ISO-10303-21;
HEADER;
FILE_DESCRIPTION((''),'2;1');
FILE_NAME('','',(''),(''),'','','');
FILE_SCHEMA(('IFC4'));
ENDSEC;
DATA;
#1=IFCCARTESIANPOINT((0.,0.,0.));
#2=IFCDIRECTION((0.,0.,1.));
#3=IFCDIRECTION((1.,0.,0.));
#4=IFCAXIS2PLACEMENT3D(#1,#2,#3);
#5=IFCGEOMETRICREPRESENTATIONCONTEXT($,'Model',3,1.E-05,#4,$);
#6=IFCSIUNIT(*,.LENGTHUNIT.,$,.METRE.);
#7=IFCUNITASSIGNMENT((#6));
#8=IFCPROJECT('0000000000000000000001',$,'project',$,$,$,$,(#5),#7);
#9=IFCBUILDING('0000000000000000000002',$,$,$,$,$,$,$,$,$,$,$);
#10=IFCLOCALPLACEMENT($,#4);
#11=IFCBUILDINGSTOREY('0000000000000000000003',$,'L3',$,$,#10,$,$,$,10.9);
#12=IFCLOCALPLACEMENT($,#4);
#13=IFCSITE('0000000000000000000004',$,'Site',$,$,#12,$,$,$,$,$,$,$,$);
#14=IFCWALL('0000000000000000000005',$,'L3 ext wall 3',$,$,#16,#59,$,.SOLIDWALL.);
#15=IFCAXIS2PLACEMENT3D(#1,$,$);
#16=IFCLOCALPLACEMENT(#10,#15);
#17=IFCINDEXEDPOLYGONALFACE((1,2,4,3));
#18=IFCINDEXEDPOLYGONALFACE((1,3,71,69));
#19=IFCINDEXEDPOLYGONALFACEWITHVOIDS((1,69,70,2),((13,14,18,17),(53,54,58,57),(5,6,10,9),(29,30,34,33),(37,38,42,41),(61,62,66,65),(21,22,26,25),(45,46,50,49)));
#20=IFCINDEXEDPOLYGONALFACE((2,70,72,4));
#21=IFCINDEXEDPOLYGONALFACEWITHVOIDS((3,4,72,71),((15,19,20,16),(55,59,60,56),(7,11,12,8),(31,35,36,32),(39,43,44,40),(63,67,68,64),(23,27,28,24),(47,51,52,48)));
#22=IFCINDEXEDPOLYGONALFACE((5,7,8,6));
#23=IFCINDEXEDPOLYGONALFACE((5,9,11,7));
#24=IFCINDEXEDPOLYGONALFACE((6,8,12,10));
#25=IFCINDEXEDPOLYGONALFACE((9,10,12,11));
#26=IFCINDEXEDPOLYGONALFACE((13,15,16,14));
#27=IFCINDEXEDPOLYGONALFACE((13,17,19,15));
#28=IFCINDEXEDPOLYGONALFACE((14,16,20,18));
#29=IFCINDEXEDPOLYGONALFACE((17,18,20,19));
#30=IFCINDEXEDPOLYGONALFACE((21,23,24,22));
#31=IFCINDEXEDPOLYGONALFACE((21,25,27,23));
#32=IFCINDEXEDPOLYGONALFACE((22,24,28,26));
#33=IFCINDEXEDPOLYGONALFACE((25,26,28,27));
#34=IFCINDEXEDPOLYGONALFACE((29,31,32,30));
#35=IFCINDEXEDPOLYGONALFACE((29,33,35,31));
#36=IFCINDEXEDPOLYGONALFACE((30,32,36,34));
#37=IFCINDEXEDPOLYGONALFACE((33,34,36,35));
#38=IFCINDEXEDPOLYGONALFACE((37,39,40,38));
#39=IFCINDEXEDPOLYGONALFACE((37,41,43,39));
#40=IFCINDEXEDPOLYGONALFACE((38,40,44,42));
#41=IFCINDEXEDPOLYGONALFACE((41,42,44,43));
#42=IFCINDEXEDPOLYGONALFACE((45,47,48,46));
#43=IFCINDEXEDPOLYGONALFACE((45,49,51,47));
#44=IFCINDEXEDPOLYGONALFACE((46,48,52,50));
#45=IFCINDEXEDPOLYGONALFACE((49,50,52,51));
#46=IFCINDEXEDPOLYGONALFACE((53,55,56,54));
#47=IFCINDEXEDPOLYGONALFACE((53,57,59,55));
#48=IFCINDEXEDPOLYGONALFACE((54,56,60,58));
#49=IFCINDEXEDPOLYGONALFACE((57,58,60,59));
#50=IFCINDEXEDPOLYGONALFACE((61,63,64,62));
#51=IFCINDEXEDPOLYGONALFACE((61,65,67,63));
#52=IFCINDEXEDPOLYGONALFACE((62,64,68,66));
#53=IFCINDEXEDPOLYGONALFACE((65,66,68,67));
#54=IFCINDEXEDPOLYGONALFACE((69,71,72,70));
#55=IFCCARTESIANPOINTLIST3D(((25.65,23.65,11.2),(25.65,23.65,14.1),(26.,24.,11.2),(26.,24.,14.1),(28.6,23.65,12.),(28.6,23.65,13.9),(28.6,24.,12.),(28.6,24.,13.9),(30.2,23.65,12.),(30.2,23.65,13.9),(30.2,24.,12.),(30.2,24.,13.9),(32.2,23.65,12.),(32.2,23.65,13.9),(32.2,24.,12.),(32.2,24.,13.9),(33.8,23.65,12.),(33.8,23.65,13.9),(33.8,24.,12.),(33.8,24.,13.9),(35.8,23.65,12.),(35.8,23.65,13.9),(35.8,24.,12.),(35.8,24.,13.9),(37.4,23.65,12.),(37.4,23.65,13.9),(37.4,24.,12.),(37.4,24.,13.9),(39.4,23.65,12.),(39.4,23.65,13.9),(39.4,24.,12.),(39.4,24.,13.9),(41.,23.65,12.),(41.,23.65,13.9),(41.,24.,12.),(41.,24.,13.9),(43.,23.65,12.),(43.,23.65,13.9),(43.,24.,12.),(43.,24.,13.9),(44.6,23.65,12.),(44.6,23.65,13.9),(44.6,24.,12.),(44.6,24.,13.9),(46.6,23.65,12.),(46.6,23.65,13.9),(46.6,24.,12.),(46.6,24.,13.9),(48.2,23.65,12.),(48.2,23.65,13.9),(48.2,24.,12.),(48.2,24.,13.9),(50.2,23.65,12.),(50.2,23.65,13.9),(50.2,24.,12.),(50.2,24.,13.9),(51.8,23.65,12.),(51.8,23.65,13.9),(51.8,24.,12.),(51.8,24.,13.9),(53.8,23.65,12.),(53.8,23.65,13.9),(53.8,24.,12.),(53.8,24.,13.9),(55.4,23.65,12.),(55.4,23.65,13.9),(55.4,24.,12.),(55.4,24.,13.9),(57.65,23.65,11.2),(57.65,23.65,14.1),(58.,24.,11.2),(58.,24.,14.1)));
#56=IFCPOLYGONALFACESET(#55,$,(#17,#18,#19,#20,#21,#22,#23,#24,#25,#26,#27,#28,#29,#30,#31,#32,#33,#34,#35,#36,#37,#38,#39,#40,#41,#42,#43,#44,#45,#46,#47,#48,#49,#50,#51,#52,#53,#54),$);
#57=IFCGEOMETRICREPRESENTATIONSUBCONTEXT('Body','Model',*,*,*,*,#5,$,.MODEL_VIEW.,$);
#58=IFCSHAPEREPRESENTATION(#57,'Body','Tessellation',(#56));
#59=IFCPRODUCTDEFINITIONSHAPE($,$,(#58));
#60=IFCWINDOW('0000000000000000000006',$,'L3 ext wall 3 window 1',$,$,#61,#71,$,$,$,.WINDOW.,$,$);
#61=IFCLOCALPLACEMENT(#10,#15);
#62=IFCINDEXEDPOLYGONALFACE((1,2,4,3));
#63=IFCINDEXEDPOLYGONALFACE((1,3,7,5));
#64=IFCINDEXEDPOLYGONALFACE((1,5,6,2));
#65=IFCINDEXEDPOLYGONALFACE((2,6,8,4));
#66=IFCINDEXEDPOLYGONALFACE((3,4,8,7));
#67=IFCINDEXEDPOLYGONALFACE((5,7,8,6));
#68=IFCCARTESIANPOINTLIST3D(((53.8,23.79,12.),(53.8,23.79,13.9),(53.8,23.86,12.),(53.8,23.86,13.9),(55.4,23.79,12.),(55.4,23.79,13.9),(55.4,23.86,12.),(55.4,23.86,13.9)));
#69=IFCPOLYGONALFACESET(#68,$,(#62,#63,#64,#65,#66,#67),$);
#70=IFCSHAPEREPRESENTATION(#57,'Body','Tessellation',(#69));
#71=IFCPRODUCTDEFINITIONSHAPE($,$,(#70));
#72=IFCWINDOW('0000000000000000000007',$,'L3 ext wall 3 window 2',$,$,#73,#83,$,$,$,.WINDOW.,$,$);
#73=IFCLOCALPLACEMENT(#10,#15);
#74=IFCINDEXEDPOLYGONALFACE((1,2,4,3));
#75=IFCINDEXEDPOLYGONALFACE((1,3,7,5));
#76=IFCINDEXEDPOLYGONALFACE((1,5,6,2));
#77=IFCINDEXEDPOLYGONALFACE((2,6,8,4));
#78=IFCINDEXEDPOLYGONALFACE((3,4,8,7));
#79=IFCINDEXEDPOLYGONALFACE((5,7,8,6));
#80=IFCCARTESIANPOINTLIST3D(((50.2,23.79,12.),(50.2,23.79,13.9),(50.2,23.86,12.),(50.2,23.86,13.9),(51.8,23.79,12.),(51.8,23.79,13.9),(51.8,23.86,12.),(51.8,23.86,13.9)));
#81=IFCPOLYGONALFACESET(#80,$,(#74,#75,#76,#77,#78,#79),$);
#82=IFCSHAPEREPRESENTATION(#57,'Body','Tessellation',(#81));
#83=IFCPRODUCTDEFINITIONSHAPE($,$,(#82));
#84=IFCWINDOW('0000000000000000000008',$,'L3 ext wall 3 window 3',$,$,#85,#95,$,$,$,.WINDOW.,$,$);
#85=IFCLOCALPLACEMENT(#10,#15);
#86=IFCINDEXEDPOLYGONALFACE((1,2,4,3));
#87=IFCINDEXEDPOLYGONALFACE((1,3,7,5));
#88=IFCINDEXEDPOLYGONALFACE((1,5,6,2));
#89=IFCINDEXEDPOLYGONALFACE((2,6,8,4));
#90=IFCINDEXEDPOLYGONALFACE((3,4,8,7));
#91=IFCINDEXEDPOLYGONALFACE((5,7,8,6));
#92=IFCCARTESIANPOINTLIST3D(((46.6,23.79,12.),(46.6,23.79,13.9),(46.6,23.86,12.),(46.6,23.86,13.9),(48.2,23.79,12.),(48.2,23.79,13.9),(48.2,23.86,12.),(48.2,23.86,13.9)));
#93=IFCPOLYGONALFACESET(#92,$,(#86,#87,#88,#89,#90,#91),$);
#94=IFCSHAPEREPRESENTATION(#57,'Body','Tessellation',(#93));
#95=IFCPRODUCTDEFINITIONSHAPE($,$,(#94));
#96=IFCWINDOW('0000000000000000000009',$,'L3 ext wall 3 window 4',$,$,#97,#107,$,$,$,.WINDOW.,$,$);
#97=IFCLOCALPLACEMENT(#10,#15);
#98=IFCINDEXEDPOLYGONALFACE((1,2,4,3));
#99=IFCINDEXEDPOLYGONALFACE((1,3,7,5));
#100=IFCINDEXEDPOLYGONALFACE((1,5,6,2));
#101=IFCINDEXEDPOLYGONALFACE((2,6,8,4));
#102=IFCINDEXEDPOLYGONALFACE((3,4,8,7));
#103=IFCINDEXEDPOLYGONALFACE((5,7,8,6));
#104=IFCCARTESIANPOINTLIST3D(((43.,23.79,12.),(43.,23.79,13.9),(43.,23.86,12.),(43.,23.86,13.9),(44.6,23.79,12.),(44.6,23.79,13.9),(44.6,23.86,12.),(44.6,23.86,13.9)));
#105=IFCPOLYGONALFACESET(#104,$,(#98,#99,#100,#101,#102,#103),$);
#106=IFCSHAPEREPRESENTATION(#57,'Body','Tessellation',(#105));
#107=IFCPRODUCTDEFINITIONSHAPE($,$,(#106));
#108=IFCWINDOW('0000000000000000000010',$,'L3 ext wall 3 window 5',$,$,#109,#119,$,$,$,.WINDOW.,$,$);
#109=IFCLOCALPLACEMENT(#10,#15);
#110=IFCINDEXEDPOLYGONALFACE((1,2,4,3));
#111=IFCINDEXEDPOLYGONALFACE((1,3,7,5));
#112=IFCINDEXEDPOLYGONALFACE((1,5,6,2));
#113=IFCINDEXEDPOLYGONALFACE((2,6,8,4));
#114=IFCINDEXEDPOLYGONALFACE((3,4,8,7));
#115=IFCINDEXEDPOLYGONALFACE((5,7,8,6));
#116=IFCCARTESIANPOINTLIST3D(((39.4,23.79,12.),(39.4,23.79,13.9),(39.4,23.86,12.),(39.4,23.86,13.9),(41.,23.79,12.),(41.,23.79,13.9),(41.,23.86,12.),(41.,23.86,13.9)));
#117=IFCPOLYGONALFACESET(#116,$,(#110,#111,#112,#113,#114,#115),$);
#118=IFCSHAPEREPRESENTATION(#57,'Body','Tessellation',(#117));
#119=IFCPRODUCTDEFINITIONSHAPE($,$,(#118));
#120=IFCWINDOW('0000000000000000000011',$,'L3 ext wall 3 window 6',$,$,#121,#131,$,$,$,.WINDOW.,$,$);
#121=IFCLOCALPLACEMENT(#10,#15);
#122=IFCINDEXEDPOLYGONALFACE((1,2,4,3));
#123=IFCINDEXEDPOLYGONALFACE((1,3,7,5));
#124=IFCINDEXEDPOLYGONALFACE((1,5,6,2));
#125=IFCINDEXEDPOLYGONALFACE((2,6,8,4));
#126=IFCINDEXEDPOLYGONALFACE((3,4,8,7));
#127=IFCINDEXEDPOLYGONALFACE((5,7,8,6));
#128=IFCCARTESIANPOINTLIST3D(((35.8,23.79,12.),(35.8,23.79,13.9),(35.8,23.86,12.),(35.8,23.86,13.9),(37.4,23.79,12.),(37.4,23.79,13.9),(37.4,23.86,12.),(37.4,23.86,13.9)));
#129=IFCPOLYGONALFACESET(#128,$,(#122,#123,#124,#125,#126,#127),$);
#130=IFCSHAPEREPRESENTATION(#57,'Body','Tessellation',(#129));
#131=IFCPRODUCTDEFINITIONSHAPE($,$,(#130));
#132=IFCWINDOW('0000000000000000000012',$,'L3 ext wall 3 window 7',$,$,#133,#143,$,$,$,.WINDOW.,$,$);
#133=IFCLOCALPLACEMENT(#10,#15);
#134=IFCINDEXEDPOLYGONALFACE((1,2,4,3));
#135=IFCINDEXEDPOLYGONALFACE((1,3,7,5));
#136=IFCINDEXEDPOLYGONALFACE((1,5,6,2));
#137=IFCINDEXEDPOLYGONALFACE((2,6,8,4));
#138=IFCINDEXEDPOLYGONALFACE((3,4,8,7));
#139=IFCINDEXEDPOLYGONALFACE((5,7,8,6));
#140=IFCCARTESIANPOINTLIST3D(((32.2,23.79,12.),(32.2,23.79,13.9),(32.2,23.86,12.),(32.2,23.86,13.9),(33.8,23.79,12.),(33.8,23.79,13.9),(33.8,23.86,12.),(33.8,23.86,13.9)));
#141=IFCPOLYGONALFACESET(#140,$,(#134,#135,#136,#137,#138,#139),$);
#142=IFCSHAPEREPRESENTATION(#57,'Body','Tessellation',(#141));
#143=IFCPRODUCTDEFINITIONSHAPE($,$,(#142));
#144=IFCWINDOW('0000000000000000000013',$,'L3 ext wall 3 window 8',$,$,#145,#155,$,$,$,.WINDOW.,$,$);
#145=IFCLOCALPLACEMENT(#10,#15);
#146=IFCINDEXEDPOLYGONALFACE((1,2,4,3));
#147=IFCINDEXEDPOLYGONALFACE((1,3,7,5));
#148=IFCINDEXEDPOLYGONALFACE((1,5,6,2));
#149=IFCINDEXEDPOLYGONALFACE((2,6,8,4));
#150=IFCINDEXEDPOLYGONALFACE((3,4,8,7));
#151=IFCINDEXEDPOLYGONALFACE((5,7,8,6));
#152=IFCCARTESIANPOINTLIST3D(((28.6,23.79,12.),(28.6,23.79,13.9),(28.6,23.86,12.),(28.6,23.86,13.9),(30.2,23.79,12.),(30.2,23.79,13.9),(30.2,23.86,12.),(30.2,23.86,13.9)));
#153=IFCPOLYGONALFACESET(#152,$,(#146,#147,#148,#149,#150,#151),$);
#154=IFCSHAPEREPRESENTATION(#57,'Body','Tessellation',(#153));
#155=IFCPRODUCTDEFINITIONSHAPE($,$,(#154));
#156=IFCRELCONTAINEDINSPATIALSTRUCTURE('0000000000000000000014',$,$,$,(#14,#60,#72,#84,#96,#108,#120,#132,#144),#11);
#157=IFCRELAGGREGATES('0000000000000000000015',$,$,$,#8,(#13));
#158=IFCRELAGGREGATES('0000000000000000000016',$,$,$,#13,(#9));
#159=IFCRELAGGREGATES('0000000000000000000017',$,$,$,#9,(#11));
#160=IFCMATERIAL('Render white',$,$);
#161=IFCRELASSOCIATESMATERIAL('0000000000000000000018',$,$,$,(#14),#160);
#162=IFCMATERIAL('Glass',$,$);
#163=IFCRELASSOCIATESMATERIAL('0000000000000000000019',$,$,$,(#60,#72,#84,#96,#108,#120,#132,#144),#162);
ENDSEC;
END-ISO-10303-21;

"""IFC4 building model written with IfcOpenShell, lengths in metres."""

from ifc_helpers import new_model, si_unit, frame, origin_with_axes, place, context, subcontext, project, spatial, polyline, outline, extrude, material, element, fill, save


model = new_model("IFC4")

# Units and contexts
model_context = context("Model", 3, precision=1e-05, world=origin_with_axes())
body_context = subcontext(model_context, "Body", "Model", "MODEL_VIEW")
ifc_project = project(units=[si_unit("LENGTHUNIT", "METRE")], contexts=[model_context])

# Site, building, storey
site_placement = place(None, origin_with_axes())
site = spatial("IfcSite", under=ifc_project, at=site_placement, Name="Site")
building = spatial("IfcBuilding", under=site)
storey_placement = place(None, origin_with_axes())
storey = spatial("IfcBuildingStorey", under=building, at=storey_placement, Name="L3", Elevation=10.9)

# Wall, openings, windows
ifc_material_1 = material(Name="Render white")
wall_1_placement = place(storey_placement, origin_with_axes())
wall_1 = element("IfcWall", 1, at=wall_1_placement, inside=storey, material=ifc_material_1, Name="L3 ext wall 3", PredefinedType="SOLIDWALL", context=body_context, shape_type="SweptSolid", body=[
    extrude(outline(polyline([(58.0, 24.0), (26.0, 24.0), (25.65, 23.65), (57.65, 23.65), (58.0, 24.0)])), frame((0.0, 0.0, 11.2), z_axis=(0.0, 0.0, 1.0), x_axis=(1.0, 0.0, 0.0)), (0.0, 0.0, 1.0), 2.9),
])
opening_1_placement = place(wall_1_placement, origin_with_axes())
opening_1 = element("IfcOpeningElement", 2, at=opening_1_placement, cuts=wall_1, context=body_context, shape_type="SweptSolid", body=[
    extrude(outline(polyline([(55.4, 24.05), (53.8, 24.05), (53.8, 23.6), (55.4, 23.6), (55.4, 24.05)])), frame((0.0, 0.0, 12.0), z_axis=(0.0, 0.0, 1.0), x_axis=(1.0, 0.0, 0.0)), (0.0, 0.0, 1.0), 1.9),
])
opening_2_placement = place(wall_1_placement, origin_with_axes())
opening_2 = element("IfcOpeningElement", 3, at=opening_2_placement, cuts=wall_1, context=body_context, shape_type="SweptSolid", body=[
    extrude(outline(polyline([(51.8, 24.05), (50.2, 24.05), (50.2, 23.6), (51.8, 23.6), (51.8, 24.05)])), frame((0.0, 0.0, 12.0), z_axis=(0.0, 0.0, 1.0), x_axis=(1.0, 0.0, 0.0)), (0.0, 0.0, 1.0), 1.9),
])
opening_3_placement = place(wall_1_placement, origin_with_axes())
opening_3 = element("IfcOpeningElement", 4, at=opening_3_placement, cuts=wall_1, context=body_context, shape_type="SweptSolid", body=[
    extrude(outline(polyline([(48.2, 24.05), (46.6, 24.05), (46.6, 23.6), (48.2, 23.6), (48.2, 24.05)])), frame((0.0, 0.0, 12.0), z_axis=(0.0, 0.0, 1.0), x_axis=(1.0, 0.0, 0.0)), (0.0, 0.0, 1.0), 1.9),
])
opening_4_placement = place(wall_1_placement, origin_with_axes())
opening_4 = element("IfcOpeningElement", 5, at=opening_4_placement, cuts=wall_1, context=body_context, shape_type="SweptSolid", body=[
    extrude(outline(polyline([(44.6, 24.05), (43.0, 24.05), (43.0, 23.6), (44.6, 23.6), (44.6, 24.05)])), frame((0.0, 0.0, 12.0), z_axis=(0.0, 0.0, 1.0), x_axis=(1.0, 0.0, 0.0)), (0.0, 0.0, 1.0), 1.9),
])
opening_5_placement = place(wall_1_placement, origin_with_axes())
opening_5 = element("IfcOpeningElement", 6, at=opening_5_placement, cuts=wall_1, context=body_context, shape_type="SweptSolid", body=[
    extrude(outline(polyline([(41.0, 24.05), (39.4, 24.05), (39.4, 23.6), (41.0, 23.6), (41.0, 24.05)])), frame((0.0, 0.0, 12.0), z_axis=(0.0, 0.0, 1.0), x_axis=(1.0, 0.0, 0.0)), (0.0, 0.0, 1.0), 1.9),
])
opening_6_placement = place(wall_1_placement, origin_with_axes())
opening_6 = element("IfcOpeningElement", 7, at=opening_6_placement, cuts=wall_1, context=body_context, shape_type="SweptSolid", body=[
    extrude(outline(polyline([(37.4, 24.05), (35.8, 24.05), (35.8, 23.6), (37.4, 23.6), (37.4, 24.05)])), frame((0.0, 0.0, 12.0), z_axis=(0.0, 0.0, 1.0), x_axis=(1.0, 0.0, 0.0)), (0.0, 0.0, 1.0), 1.9),
])
opening_7_placement = place(wall_1_placement, origin_with_axes())
opening_7 = element("IfcOpeningElement", 8, at=opening_7_placement, cuts=wall_1, context=body_context, shape_type="SweptSolid", body=[
    extrude(outline(polyline([(33.8, 24.05), (32.2, 24.05), (32.2, 23.6), (33.8, 23.6), (33.8, 24.05)])), frame((0.0, 0.0, 12.0), z_axis=(0.0, 0.0, 1.0), x_axis=(1.0, 0.0, 0.0)), (0.0, 0.0, 1.0), 1.9),
])
opening_8_placement = place(wall_1_placement, origin_with_axes())
opening_8 = element("IfcOpeningElement", 9, at=opening_8_placement, cuts=wall_1, context=body_context, shape_type="SweptSolid", body=[
    extrude(outline(polyline([(30.2, 24.05), (28.6, 24.05), (28.6, 23.6), (30.2, 23.6), (30.2, 24.05)])), frame((0.0, 0.0, 12.0), z_axis=(0.0, 0.0, 1.0), x_axis=(1.0, 0.0, 0.0)), (0.0, 0.0, 1.0), 1.9),
])
ifc_material_2 = material(Name="Glass")
window_1_placement = place(storey_placement, origin_with_axes())
window_1 = element("IfcWindow", 10, at=window_1_placement, inside=storey, material=ifc_material_2, Name="L3 ext wall 3 window 1", PredefinedType="WINDOW", context=body_context, shape_type="SweptSolid", body=[
    extrude(outline(polyline([(55.4, 23.86), (53.8, 23.86), (53.8, 23.79), (55.4, 23.79), (55.4, 23.86)])), frame((0.0, 0.0, 12.0), z_axis=(0.0, 0.0, 1.0), x_axis=(1.0, 0.0, 0.0)), (0.0, 0.0, 1.0), 1.9),
])
fill(opening_1, window_1)
window_2_placement = place(storey_placement, origin_with_axes())
window_2 = element("IfcWindow", 11, at=window_2_placement, inside=storey, material=ifc_material_2, Name="L3 ext wall 3 window 2", PredefinedType="WINDOW", context=body_context, shape_type="SweptSolid", body=[
    extrude(outline(polyline([(51.8, 23.86), (50.2, 23.86), (50.2, 23.79), (51.8, 23.79), (51.8, 23.86)])), frame((0.0, 0.0, 12.0), z_axis=(0.0, 0.0, 1.0), x_axis=(1.0, 0.0, 0.0)), (0.0, 0.0, 1.0), 1.9),
])
fill(opening_2, window_2)
window_3_placement = place(storey_placement, origin_with_axes())
window_3 = element("IfcWindow", 12, at=window_3_placement, inside=storey, material=ifc_material_2, Name="L3 ext wall 3 window 3", PredefinedType="WINDOW", context=body_context, shape_type="SweptSolid", body=[
    extrude(outline(polyline([(48.2, 23.86), (46.6, 23.86), (46.6, 23.79), (48.2, 23.79), (48.2, 23.86)])), frame((0.0, 0.0, 12.0), z_axis=(0.0, 0.0, 1.0), x_axis=(1.0, 0.0, 0.0)), (0.0, 0.0, 1.0), 1.9),
])
fill(opening_3, window_3)
window_4_placement = place(storey_placement, origin_with_axes())
window_4 = element("IfcWindow", 13, at=window_4_placement, inside=storey, material=ifc_material_2, Name="L3 ext wall 3 window 4", PredefinedType="WINDOW", context=body_context, shape_type="SweptSolid", body=[
    extrude(outline(polyline([(44.6, 23.86), (43.0, 23.86), (43.0, 23.79), (44.6, 23.79), (44.6, 23.86)])), frame((0.0, 0.0, 12.0), z_axis=(0.0, 0.0, 1.0), x_axis=(1.0, 0.0, 0.0)), (0.0, 0.0, 1.0), 1.9),
])
fill(opening_4, window_4)
window_5_placement = place(storey_placement, origin_with_axes())
window_5 = element("IfcWindow", 14, at=window_5_placement, inside=storey, material=ifc_material_2, Name="L3 ext wall 3 window 5", PredefinedType="WINDOW", context=body_context, shape_type="SweptSolid", body=[
    extrude(outline(polyline([(41.0, 23.86), (39.4, 23.86), (39.4, 23.79), (41.0, 23.79), (41.0, 23.86)])), frame((0.0, 0.0, 12.0), z_axis=(0.0, 0.0, 1.0), x_axis=(1.0, 0.0, 0.0)), (0.0, 0.0, 1.0), 1.9),
])
fill(opening_5, window_5)
window_6_placement = place(storey_placement, origin_with_axes())
window_6 = element("IfcWindow", 15, at=window_6_placement, inside=storey, material=ifc_material_2, Name="L3 ext wall 3 window 6", PredefinedType="WINDOW", context=body_context, shape_type="SweptSolid", body=[
    extrude(outline(polyline([(37.4, 23.86), (35.8, 23.86), (35.8, 23.79), (37.4, 23.79), (37.4, 23.86)])), frame((0.0, 0.0, 12.0), z_axis=(0.0, 0.0, 1.0), x_axis=(1.0, 0.0, 0.0)), (0.0, 0.0, 1.0), 1.9),
])
fill(opening_6, window_6)
window_7_placement = place(storey_placement, origin_with_axes())
window_7 = element("IfcWindow", 16, at=window_7_placement, inside=storey, material=ifc_material_2, Name="L3 ext wall 3 window 7", PredefinedType="WINDOW", context=body_context, shape_type="SweptSolid", body=[
    extrude(outline(polyline([(33.8, 23.86), (32.2, 23.86), (32.2, 23.79), (33.8, 23.79), (33.8, 23.86)])), frame((0.0, 0.0, 12.0), z_axis=(0.0, 0.0, 1.0), x_axis=(1.0, 0.0, 0.0)), (0.0, 0.0, 1.0), 1.9),
])
fill(opening_7, window_7)
window_8_placement = place(storey_placement, origin_with_axes())
window_8 = element("IfcWindow", 17, at=window_8_placement, inside=storey, material=ifc_material_2, Name="L3 ext wall 3 window 8", PredefinedType="WINDOW", context=body_context, shape_type="SweptSolid", body=[
    extrude(outline(polyline([(30.2, 23.86), (28.6, 23.86), (28.6, 23.79), (30.2, 23.79), (30.2, 23.86)])), frame((0.0, 0.0, 12.0), z_axis=(0.0, 0.0, 1.0), x_axis=(1.0, 0.0, 0.0)), (0.0, 0.0, 1.0), 1.9),
])
fill(opening_8, window_8)

save(model, "model.ifc")
